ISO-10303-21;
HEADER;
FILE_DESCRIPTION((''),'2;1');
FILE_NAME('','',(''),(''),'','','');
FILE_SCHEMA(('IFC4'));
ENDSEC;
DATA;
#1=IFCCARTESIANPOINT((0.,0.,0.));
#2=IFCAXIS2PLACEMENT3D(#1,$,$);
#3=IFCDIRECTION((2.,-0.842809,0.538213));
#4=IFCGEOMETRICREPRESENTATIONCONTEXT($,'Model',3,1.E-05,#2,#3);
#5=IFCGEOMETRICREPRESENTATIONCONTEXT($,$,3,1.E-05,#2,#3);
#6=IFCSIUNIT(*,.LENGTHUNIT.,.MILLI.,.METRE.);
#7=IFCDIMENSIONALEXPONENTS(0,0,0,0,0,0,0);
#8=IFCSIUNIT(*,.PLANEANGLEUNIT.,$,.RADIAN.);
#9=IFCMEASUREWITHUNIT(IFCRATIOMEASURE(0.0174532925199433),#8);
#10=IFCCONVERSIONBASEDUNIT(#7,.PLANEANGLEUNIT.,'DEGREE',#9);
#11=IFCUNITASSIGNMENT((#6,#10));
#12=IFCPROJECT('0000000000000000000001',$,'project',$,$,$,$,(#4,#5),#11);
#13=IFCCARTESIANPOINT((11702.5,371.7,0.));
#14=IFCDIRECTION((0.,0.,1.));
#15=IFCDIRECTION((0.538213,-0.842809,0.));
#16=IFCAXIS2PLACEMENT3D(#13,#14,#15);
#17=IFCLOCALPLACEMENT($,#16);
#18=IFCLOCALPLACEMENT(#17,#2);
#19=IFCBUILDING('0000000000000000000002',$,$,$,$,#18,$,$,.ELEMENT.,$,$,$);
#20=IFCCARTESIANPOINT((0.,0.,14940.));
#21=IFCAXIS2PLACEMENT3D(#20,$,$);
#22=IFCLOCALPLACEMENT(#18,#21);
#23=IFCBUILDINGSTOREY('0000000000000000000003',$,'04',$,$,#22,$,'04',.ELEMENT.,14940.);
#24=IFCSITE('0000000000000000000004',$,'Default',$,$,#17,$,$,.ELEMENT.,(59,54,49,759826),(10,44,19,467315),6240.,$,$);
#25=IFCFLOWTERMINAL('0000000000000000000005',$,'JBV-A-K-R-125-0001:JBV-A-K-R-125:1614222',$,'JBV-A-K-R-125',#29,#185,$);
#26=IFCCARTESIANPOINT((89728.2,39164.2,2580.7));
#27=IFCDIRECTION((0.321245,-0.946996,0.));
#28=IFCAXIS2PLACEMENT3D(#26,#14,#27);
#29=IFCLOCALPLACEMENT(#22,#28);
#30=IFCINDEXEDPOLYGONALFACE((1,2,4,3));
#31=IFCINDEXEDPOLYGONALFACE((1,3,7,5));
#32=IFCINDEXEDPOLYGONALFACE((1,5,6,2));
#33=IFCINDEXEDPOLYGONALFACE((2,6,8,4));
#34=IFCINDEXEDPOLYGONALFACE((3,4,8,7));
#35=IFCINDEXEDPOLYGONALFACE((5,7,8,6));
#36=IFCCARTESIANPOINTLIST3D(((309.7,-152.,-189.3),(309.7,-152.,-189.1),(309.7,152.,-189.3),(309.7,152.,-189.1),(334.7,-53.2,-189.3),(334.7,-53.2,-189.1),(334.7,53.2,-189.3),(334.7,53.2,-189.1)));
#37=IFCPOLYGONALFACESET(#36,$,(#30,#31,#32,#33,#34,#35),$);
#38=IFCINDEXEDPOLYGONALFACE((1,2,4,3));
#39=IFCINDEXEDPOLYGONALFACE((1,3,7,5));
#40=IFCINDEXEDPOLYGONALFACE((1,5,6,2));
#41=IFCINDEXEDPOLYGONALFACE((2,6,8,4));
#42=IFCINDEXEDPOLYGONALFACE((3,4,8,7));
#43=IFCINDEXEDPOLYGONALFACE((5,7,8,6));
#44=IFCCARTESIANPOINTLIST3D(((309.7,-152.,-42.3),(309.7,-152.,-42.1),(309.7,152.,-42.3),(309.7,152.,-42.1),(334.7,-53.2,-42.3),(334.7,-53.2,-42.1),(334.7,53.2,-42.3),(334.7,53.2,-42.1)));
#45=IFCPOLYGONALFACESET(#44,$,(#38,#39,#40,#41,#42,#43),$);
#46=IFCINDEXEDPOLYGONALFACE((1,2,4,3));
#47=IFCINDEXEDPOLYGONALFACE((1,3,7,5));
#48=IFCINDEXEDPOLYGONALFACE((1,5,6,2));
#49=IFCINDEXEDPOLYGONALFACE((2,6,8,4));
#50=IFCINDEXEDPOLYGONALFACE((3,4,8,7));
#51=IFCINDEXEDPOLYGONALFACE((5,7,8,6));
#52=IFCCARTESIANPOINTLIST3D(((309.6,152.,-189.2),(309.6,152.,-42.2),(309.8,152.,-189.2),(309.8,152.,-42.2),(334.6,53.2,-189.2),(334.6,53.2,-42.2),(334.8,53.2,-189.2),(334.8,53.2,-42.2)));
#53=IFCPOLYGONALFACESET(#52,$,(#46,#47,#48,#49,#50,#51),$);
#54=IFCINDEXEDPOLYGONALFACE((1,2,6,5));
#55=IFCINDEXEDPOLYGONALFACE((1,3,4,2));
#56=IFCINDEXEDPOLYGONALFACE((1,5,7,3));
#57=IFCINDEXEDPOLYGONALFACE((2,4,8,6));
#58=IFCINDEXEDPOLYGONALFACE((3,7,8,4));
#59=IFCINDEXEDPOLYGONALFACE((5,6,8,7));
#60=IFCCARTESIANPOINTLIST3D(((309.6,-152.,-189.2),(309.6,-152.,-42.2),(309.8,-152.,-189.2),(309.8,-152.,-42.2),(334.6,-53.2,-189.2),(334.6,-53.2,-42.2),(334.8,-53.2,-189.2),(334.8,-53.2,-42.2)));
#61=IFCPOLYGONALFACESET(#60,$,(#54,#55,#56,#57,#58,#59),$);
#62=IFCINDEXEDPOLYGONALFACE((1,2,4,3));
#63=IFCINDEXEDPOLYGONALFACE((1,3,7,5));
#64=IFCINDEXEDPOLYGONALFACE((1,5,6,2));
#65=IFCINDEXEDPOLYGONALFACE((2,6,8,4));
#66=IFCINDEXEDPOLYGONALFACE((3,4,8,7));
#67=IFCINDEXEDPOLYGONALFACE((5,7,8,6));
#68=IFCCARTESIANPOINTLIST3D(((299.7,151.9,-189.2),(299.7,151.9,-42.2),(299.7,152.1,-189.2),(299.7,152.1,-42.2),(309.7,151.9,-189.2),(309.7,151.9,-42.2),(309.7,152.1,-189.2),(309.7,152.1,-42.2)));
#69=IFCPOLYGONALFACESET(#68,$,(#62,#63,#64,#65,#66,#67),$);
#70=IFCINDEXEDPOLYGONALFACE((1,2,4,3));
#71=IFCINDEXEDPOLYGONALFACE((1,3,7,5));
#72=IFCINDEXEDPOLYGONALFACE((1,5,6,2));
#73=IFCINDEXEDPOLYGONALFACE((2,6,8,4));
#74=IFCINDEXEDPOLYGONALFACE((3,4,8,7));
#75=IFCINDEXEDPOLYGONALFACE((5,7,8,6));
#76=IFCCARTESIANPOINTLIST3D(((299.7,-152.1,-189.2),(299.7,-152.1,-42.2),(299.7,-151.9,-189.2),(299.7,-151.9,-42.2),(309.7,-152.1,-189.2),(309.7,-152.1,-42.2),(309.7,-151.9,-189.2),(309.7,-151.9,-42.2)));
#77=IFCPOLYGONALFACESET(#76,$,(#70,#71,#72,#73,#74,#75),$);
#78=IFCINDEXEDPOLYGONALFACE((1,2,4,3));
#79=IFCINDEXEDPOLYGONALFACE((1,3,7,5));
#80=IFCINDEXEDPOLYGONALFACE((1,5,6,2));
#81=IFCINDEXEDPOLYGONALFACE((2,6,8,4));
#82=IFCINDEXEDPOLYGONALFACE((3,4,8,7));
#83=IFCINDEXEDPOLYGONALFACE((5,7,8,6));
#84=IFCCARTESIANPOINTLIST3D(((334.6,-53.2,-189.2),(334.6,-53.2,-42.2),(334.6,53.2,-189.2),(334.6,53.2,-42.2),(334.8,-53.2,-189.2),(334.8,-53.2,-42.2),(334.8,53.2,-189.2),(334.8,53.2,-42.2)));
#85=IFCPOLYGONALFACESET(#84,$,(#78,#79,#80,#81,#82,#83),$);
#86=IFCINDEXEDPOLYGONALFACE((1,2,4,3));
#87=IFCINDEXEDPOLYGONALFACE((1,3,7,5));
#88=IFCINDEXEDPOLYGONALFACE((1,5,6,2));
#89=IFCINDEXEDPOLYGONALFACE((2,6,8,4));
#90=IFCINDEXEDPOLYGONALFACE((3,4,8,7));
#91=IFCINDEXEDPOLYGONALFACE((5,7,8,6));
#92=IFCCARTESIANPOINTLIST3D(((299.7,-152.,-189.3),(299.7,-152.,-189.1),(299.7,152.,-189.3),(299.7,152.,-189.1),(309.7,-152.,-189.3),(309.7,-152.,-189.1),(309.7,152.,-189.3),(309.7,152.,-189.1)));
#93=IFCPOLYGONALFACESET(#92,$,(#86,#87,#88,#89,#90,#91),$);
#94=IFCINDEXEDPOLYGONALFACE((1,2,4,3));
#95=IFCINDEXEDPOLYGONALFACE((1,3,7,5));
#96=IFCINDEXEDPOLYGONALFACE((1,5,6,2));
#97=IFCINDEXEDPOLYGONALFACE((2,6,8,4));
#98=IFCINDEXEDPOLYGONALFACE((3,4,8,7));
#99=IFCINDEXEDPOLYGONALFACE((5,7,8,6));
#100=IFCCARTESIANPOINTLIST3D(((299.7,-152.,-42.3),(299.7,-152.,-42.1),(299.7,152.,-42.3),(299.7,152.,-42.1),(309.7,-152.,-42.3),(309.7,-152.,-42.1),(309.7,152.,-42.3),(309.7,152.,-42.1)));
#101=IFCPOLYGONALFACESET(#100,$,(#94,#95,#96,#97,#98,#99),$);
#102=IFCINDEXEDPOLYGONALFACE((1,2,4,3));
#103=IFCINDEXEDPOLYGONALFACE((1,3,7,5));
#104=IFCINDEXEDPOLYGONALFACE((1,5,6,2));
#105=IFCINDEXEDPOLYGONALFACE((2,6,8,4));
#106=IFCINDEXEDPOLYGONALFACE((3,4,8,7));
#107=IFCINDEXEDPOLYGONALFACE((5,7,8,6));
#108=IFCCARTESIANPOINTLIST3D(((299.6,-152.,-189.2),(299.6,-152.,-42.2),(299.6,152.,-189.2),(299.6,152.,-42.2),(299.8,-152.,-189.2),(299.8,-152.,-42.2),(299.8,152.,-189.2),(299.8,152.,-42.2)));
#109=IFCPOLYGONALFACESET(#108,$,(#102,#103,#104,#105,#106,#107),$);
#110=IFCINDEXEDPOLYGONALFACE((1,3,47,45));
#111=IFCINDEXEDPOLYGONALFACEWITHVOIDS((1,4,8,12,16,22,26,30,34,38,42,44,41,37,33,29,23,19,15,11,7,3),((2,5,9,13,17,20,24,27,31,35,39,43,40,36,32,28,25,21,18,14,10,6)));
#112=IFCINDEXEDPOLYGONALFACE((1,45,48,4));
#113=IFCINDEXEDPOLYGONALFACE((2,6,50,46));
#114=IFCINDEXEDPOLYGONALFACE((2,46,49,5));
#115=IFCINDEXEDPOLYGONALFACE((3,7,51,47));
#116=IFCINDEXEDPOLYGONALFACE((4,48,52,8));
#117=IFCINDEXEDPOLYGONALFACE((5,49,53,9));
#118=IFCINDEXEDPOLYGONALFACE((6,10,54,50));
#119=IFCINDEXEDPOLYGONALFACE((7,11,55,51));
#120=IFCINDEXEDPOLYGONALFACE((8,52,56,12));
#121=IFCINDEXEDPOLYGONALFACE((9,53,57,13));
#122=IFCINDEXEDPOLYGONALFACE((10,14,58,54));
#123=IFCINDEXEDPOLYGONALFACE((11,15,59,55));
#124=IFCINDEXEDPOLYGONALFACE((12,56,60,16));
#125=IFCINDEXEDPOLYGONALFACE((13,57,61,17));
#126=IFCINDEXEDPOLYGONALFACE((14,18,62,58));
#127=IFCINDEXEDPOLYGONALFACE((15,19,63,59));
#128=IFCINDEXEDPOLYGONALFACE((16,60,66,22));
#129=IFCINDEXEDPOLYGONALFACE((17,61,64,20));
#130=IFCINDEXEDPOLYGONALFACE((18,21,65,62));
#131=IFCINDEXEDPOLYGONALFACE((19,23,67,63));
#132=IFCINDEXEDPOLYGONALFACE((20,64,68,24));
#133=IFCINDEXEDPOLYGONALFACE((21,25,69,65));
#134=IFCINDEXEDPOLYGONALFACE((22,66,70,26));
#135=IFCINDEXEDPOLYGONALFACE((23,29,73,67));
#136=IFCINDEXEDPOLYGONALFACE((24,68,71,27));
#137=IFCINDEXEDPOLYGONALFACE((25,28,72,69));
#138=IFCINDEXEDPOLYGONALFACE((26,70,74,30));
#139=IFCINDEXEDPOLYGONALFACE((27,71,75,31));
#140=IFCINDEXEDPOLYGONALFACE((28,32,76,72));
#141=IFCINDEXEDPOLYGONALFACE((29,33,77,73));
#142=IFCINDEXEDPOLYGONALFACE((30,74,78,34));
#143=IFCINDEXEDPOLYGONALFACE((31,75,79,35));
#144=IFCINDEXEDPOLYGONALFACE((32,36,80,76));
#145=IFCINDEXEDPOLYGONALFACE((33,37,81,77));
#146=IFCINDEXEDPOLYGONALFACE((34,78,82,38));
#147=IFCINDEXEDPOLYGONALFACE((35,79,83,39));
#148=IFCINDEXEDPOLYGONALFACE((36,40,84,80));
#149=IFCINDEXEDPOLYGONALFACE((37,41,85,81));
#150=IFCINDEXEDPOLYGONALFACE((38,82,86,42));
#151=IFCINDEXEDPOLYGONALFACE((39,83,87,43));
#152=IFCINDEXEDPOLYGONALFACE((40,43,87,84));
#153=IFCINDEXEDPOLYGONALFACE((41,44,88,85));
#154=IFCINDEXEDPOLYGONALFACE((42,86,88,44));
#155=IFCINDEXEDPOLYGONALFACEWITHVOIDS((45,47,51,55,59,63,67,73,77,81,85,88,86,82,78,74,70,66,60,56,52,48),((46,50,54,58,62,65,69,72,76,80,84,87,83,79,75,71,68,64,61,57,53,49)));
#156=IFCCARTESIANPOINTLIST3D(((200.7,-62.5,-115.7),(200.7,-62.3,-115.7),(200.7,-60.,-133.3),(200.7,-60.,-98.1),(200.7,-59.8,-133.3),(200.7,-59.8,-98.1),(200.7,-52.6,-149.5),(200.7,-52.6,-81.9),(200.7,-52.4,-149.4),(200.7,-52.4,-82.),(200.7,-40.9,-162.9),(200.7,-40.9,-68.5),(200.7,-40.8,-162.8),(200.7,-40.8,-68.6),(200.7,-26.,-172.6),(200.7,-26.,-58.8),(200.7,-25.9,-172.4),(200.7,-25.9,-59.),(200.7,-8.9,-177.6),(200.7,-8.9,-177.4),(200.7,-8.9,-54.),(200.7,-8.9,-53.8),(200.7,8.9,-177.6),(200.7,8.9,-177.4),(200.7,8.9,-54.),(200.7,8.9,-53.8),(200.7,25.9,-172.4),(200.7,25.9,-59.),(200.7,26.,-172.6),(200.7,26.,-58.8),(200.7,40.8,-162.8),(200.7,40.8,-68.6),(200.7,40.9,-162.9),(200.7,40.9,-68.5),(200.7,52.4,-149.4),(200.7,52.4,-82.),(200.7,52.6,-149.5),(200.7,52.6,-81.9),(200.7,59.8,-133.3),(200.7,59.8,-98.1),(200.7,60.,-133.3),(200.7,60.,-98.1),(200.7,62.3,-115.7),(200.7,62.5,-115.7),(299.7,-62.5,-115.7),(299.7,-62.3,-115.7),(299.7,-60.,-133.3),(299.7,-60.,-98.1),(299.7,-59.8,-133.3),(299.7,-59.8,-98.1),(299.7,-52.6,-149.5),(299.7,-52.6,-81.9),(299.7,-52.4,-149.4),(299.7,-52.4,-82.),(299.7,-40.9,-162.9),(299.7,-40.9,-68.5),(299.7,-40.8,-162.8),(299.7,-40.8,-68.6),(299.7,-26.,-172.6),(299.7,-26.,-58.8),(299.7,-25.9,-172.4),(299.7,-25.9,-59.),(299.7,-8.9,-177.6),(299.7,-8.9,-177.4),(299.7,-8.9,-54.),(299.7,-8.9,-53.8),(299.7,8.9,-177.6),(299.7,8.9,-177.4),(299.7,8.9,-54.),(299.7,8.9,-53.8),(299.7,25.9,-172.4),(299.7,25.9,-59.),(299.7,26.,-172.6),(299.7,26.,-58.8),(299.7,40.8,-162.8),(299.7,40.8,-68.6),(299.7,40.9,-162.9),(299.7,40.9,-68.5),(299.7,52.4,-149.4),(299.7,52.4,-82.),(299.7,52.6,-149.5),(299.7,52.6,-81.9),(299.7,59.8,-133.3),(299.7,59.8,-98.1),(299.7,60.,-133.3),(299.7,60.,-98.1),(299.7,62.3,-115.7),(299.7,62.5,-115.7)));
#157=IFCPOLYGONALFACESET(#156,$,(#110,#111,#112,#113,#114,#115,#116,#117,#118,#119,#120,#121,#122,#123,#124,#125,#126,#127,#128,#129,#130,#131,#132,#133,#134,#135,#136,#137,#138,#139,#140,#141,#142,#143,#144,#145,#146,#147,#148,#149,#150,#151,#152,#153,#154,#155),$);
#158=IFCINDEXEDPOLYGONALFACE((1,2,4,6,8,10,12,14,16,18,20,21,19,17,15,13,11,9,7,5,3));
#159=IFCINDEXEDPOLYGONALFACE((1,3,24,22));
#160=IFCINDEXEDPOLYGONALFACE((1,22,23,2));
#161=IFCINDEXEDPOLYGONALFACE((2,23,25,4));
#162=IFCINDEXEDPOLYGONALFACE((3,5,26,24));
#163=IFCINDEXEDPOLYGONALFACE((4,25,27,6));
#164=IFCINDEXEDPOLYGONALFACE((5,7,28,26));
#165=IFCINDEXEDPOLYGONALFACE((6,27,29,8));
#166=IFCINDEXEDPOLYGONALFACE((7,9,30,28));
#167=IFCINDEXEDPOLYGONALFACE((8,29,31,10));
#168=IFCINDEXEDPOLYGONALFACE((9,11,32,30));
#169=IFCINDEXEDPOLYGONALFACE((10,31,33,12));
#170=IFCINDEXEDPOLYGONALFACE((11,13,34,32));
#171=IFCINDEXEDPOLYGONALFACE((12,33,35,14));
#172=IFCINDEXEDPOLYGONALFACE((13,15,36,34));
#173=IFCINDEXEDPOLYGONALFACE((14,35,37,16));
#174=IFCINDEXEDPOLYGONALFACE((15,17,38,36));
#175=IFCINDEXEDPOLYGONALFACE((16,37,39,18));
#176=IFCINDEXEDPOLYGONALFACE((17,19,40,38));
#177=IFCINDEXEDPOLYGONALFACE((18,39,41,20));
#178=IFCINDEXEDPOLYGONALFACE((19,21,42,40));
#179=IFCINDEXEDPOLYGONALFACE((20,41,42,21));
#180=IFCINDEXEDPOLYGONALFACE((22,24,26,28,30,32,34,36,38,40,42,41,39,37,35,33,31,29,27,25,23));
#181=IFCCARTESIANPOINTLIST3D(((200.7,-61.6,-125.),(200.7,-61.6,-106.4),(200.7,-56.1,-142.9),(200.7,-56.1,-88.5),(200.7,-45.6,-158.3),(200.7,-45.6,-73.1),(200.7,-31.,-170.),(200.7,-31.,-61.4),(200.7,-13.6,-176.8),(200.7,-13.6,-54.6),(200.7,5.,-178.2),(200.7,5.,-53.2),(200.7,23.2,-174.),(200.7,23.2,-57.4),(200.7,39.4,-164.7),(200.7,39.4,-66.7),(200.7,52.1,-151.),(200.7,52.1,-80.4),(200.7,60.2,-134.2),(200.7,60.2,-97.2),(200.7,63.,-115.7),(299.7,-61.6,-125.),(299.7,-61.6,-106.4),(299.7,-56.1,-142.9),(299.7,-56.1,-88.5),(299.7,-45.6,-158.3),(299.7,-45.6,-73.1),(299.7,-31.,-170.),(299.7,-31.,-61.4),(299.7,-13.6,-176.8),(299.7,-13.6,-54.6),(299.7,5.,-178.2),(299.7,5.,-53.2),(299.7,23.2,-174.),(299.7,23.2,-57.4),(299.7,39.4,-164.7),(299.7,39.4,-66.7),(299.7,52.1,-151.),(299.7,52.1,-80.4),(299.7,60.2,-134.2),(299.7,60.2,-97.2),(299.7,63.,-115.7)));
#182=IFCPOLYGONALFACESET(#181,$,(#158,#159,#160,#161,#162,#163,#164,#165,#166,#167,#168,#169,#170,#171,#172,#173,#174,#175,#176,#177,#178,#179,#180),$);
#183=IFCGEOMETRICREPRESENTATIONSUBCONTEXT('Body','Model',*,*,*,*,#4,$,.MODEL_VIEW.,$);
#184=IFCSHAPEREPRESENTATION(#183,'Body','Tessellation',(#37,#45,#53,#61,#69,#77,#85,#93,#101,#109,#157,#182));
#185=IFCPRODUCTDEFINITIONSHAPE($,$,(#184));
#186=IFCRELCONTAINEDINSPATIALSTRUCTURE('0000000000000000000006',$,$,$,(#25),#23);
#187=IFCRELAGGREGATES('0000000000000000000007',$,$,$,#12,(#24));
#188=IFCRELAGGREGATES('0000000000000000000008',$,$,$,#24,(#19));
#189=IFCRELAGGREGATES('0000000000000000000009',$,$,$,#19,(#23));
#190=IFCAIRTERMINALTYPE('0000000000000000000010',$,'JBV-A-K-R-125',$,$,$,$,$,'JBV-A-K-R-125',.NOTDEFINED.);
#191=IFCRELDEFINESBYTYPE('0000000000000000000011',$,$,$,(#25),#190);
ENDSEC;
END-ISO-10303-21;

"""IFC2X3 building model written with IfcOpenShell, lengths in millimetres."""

from ifc_helpers import new_model, entity, si_unit, converted_unit, direction, frame, frame_2d, origin, origin_2d_with_axis, place, context, subcontext, project, spatial, polyline, circle_curve, parameter, trimmed, segment, composite_curve, rectangle, circle, outline, extrude, source, transform, mapped, type_object, type_shapes, element, save


model = new_model("IFC2X3")

# Units and contexts
model_context = context("Model", 3, precision=1e-05, world=origin(), true_north=direction((2.0, -0.842809, 0.538213)))
context_of_model = context(None, 3, precision=1e-05, world=origin(), true_north=direction((2.0, -0.842809, 0.538213)))
body_context = subcontext(model_context, "Body", "Model", "MODEL_VIEW")
ifc_project = project(units=[si_unit("LENGTHUNIT", "METRE", prefix="MILLI"), converted_unit("PLANEANGLEUNIT", "DEGREE", entity("IfcRatioMeasure", 0.0174532925199433), si_unit("PLANEANGLEUNIT", "RADIAN"), dimensions=[0, 0, 0, 0, 0, 0, 0])], contexts=[model_context, context_of_model])

# Site, building, storey
site_placement = place(None, frame((11702.5, 371.7, 0.0), z_axis=(0.0, 0.0, 1.0), x_axis=(0.538213, -0.842809, 0.0)))
site = spatial("IfcSite", under=ifc_project, at=site_placement, Name="Default", CompositionType="ELEMENT", RefLatitude=(59, 54, 49, 759826), RefLongitude=(10, 44, 19, 467315), RefElevation=6240.0)
building_placement = place(site_placement, origin())
building = spatial("IfcBuilding", under=site, at=building_placement, CompositionType="ELEMENT")
storey_placement = place(building_placement, frame((0.0, 0.0, 14940.0)))
storey = spatial("IfcBuildingStorey", under=building, at=storey_placement, Name="04", LongName="04", CompositionType="ELEMENT", Elevation=14940.0)

# Flow terminal
air_terminal_type_1 = type_object("IfcAirTerminalType", Name="JBV-A-K-R-125", ElementType="JBV-A-K-R-125", PredefinedType="NOTDEFINED")
shared_shape_1 = source(origin(), body_context, "Body", "SweptSolid", [
    extrude(outline(polyline([(-152.0, -12.5), (152.0, -12.5), (53.2, 12.5), (-53.2, 12.5), (-152.0, -12.5)])), frame((322.2, 0.0, -189.3), z_axis=(0.0, 0.0, 1.0), x_axis=(0.0, -1.0, 0.0)), (0.0, 0.0, 1.0), 0.2),
    extrude(outline(polyline([(-152.0, -12.5), (152.0, -12.5), (53.2, 12.5), (-53.2, 12.5), (-152.0, -12.5)])), frame((322.2, 0.0, -42.3), z_axis=(0.0, 0.0, 1.0), x_axis=(0.0, -1.0, 0.0)), (0.0, 0.0, 1.0), 0.2),
    extrude(rectangle(XDim=0.2, YDim=101.9, at=frame_2d((0.0, 0.0), x_axis=(1.0, 0.0))), frame((322.2, 102.6, -189.2), z_axis=(0.0, 0.0, 1.0), x_axis=(0.969446, 0.245305, 0.0)), (0.0, 0.0, 1.0), 147.0),
    extrude(rectangle(XDim=0.2, YDim=101.9, at=frame_2d((0.0, 0.0), x_axis=(1.0, 0.0))), frame((322.2, -102.6, -189.2), z_axis=(0.0, 0.0, 1.0), x_axis=(-0.969446, 0.245305, 0.0)), (0.0, 0.0, 1.0), 147.0),
    extrude(rectangle(XDim=0.2, YDim=10.0, at=frame_2d((0.0, 0.0), x_axis=(1.0, 0.0))), frame((304.7, 152.0, -189.2), z_axis=(0.0, 0.0, 1.0), x_axis=(0.0, 1.0, 0.0)), (0.0, 0.0, 1.0), 147.0),
    extrude(rectangle(XDim=0.2, YDim=10.0, at=frame_2d((0.0, 0.0), x_axis=(1.0, 0.0))), frame((304.7, -152.0, -189.2), z_axis=(0.0, 0.0, 1.0), x_axis=(0.0, 1.0, 0.0)), (0.0, 0.0, 1.0), 147.0),
    extrude(rectangle(XDim=0.2, YDim=106.4, at=frame_2d((0.0, 0.0), x_axis=(1.0, 0.0))), frame((334.7, 0.0, -189.2)), (0.0, 0.0, 1.0), 147.0),
    extrude(rectangle(XDim=304.0, YDim=10.0, at=frame_2d((0.0, 0.0), x_axis=(1.0, 0.0))), frame((304.7, 0.0, -189.3), z_axis=(0.0, 0.0, 1.0), x_axis=(0.0, -1.0, 0.0)), (0.0, 0.0, 1.0), 0.2),
    extrude(rectangle(XDim=304.0, YDim=10.0, at=frame_2d((0.0, 0.0), x_axis=(1.0, 0.0))), frame((304.7, 0.0, -42.3), z_axis=(0.0, 0.0, 1.0), x_axis=(0.0, -1.0, 0.0)), (0.0, 0.0, 1.0), 0.2),
    extrude(rectangle(XDim=0.2, YDim=304.0, at=frame_2d((0.0, 0.0), x_axis=(1.0, 0.0))), frame((299.7, 0.0, -189.2)), (0.0, 0.0, 1.0), 147.0),
    extrude(outline(composite_curve([segment(trimmed(circle_curve(origin_2d_with_axis(), 62.5), [parameter(0.0)], [parameter(180.0)], True, "PARAMETER"), True, "CONTINUOUS"), segment(trimmed(circle_curve(origin_2d_with_axis(), 62.5), [parameter(180.0)], [parameter(360.0)], True, "PARAMETER"), True, "CONTINUOUS")], self_intersect=False), holes=[composite_curve([segment(trimmed(circle_curve(origin_2d_with_axis(), 62.3), [parameter(180.0)], [parameter(360.0)], True, "PARAMETER"), False, "CONTINUOUS"), segment(trimmed(circle_curve(origin_2d_with_axis(), 62.3), [parameter(0.0)], [parameter(180.0)], True, "PARAMETER"), False, "CONTINUOUS")], self_intersect=False)]), frame((200.7, 0.0, -115.7), z_axis=(1.0, 0.0, 0.0), x_axis=(0.0, 1.0, 0.0)), (0.0, 0.0, 1.0), 99.0),
    extrude(circle(Radius=62.6, at=frame_2d((0.0, 0.0), x_axis=(1.0, 0.0))), frame((200.7, 0.3, -115.7), z_axis=(1.0, 0.0, 0.0), x_axis=(0.0, 1.0, 0.0)), (0.0, 0.0, 1.0), 99.0),
])
type_shapes(air_terminal_type_1, [shared_shape_1])
for number, where, z_axis, x_axis, name in (
    (1, (89728.2, 39164.2, 2580.7), (0.0, 0.0, 1.0), (0.321245, -0.946996, 0.0), "JBV-A-K-R-125-0001:JBV-A-K-R-125:1614222"),
):
    element("IfcFlowTerminal", number, at=place(storey_placement, frame(where, z_axis=z_axis, x_axis=x_axis)), inside=storey, type_object=air_terminal_type_1, Name=name, ObjectType="JBV-A-K-R-125", context=body_context, shape_type="MappedRepresentation", body=[
        mapped(shared_shape_1, transform((0.0, 0.0, 0.0), scale=1.0)),
    ])

save(model, "model.ifc")
